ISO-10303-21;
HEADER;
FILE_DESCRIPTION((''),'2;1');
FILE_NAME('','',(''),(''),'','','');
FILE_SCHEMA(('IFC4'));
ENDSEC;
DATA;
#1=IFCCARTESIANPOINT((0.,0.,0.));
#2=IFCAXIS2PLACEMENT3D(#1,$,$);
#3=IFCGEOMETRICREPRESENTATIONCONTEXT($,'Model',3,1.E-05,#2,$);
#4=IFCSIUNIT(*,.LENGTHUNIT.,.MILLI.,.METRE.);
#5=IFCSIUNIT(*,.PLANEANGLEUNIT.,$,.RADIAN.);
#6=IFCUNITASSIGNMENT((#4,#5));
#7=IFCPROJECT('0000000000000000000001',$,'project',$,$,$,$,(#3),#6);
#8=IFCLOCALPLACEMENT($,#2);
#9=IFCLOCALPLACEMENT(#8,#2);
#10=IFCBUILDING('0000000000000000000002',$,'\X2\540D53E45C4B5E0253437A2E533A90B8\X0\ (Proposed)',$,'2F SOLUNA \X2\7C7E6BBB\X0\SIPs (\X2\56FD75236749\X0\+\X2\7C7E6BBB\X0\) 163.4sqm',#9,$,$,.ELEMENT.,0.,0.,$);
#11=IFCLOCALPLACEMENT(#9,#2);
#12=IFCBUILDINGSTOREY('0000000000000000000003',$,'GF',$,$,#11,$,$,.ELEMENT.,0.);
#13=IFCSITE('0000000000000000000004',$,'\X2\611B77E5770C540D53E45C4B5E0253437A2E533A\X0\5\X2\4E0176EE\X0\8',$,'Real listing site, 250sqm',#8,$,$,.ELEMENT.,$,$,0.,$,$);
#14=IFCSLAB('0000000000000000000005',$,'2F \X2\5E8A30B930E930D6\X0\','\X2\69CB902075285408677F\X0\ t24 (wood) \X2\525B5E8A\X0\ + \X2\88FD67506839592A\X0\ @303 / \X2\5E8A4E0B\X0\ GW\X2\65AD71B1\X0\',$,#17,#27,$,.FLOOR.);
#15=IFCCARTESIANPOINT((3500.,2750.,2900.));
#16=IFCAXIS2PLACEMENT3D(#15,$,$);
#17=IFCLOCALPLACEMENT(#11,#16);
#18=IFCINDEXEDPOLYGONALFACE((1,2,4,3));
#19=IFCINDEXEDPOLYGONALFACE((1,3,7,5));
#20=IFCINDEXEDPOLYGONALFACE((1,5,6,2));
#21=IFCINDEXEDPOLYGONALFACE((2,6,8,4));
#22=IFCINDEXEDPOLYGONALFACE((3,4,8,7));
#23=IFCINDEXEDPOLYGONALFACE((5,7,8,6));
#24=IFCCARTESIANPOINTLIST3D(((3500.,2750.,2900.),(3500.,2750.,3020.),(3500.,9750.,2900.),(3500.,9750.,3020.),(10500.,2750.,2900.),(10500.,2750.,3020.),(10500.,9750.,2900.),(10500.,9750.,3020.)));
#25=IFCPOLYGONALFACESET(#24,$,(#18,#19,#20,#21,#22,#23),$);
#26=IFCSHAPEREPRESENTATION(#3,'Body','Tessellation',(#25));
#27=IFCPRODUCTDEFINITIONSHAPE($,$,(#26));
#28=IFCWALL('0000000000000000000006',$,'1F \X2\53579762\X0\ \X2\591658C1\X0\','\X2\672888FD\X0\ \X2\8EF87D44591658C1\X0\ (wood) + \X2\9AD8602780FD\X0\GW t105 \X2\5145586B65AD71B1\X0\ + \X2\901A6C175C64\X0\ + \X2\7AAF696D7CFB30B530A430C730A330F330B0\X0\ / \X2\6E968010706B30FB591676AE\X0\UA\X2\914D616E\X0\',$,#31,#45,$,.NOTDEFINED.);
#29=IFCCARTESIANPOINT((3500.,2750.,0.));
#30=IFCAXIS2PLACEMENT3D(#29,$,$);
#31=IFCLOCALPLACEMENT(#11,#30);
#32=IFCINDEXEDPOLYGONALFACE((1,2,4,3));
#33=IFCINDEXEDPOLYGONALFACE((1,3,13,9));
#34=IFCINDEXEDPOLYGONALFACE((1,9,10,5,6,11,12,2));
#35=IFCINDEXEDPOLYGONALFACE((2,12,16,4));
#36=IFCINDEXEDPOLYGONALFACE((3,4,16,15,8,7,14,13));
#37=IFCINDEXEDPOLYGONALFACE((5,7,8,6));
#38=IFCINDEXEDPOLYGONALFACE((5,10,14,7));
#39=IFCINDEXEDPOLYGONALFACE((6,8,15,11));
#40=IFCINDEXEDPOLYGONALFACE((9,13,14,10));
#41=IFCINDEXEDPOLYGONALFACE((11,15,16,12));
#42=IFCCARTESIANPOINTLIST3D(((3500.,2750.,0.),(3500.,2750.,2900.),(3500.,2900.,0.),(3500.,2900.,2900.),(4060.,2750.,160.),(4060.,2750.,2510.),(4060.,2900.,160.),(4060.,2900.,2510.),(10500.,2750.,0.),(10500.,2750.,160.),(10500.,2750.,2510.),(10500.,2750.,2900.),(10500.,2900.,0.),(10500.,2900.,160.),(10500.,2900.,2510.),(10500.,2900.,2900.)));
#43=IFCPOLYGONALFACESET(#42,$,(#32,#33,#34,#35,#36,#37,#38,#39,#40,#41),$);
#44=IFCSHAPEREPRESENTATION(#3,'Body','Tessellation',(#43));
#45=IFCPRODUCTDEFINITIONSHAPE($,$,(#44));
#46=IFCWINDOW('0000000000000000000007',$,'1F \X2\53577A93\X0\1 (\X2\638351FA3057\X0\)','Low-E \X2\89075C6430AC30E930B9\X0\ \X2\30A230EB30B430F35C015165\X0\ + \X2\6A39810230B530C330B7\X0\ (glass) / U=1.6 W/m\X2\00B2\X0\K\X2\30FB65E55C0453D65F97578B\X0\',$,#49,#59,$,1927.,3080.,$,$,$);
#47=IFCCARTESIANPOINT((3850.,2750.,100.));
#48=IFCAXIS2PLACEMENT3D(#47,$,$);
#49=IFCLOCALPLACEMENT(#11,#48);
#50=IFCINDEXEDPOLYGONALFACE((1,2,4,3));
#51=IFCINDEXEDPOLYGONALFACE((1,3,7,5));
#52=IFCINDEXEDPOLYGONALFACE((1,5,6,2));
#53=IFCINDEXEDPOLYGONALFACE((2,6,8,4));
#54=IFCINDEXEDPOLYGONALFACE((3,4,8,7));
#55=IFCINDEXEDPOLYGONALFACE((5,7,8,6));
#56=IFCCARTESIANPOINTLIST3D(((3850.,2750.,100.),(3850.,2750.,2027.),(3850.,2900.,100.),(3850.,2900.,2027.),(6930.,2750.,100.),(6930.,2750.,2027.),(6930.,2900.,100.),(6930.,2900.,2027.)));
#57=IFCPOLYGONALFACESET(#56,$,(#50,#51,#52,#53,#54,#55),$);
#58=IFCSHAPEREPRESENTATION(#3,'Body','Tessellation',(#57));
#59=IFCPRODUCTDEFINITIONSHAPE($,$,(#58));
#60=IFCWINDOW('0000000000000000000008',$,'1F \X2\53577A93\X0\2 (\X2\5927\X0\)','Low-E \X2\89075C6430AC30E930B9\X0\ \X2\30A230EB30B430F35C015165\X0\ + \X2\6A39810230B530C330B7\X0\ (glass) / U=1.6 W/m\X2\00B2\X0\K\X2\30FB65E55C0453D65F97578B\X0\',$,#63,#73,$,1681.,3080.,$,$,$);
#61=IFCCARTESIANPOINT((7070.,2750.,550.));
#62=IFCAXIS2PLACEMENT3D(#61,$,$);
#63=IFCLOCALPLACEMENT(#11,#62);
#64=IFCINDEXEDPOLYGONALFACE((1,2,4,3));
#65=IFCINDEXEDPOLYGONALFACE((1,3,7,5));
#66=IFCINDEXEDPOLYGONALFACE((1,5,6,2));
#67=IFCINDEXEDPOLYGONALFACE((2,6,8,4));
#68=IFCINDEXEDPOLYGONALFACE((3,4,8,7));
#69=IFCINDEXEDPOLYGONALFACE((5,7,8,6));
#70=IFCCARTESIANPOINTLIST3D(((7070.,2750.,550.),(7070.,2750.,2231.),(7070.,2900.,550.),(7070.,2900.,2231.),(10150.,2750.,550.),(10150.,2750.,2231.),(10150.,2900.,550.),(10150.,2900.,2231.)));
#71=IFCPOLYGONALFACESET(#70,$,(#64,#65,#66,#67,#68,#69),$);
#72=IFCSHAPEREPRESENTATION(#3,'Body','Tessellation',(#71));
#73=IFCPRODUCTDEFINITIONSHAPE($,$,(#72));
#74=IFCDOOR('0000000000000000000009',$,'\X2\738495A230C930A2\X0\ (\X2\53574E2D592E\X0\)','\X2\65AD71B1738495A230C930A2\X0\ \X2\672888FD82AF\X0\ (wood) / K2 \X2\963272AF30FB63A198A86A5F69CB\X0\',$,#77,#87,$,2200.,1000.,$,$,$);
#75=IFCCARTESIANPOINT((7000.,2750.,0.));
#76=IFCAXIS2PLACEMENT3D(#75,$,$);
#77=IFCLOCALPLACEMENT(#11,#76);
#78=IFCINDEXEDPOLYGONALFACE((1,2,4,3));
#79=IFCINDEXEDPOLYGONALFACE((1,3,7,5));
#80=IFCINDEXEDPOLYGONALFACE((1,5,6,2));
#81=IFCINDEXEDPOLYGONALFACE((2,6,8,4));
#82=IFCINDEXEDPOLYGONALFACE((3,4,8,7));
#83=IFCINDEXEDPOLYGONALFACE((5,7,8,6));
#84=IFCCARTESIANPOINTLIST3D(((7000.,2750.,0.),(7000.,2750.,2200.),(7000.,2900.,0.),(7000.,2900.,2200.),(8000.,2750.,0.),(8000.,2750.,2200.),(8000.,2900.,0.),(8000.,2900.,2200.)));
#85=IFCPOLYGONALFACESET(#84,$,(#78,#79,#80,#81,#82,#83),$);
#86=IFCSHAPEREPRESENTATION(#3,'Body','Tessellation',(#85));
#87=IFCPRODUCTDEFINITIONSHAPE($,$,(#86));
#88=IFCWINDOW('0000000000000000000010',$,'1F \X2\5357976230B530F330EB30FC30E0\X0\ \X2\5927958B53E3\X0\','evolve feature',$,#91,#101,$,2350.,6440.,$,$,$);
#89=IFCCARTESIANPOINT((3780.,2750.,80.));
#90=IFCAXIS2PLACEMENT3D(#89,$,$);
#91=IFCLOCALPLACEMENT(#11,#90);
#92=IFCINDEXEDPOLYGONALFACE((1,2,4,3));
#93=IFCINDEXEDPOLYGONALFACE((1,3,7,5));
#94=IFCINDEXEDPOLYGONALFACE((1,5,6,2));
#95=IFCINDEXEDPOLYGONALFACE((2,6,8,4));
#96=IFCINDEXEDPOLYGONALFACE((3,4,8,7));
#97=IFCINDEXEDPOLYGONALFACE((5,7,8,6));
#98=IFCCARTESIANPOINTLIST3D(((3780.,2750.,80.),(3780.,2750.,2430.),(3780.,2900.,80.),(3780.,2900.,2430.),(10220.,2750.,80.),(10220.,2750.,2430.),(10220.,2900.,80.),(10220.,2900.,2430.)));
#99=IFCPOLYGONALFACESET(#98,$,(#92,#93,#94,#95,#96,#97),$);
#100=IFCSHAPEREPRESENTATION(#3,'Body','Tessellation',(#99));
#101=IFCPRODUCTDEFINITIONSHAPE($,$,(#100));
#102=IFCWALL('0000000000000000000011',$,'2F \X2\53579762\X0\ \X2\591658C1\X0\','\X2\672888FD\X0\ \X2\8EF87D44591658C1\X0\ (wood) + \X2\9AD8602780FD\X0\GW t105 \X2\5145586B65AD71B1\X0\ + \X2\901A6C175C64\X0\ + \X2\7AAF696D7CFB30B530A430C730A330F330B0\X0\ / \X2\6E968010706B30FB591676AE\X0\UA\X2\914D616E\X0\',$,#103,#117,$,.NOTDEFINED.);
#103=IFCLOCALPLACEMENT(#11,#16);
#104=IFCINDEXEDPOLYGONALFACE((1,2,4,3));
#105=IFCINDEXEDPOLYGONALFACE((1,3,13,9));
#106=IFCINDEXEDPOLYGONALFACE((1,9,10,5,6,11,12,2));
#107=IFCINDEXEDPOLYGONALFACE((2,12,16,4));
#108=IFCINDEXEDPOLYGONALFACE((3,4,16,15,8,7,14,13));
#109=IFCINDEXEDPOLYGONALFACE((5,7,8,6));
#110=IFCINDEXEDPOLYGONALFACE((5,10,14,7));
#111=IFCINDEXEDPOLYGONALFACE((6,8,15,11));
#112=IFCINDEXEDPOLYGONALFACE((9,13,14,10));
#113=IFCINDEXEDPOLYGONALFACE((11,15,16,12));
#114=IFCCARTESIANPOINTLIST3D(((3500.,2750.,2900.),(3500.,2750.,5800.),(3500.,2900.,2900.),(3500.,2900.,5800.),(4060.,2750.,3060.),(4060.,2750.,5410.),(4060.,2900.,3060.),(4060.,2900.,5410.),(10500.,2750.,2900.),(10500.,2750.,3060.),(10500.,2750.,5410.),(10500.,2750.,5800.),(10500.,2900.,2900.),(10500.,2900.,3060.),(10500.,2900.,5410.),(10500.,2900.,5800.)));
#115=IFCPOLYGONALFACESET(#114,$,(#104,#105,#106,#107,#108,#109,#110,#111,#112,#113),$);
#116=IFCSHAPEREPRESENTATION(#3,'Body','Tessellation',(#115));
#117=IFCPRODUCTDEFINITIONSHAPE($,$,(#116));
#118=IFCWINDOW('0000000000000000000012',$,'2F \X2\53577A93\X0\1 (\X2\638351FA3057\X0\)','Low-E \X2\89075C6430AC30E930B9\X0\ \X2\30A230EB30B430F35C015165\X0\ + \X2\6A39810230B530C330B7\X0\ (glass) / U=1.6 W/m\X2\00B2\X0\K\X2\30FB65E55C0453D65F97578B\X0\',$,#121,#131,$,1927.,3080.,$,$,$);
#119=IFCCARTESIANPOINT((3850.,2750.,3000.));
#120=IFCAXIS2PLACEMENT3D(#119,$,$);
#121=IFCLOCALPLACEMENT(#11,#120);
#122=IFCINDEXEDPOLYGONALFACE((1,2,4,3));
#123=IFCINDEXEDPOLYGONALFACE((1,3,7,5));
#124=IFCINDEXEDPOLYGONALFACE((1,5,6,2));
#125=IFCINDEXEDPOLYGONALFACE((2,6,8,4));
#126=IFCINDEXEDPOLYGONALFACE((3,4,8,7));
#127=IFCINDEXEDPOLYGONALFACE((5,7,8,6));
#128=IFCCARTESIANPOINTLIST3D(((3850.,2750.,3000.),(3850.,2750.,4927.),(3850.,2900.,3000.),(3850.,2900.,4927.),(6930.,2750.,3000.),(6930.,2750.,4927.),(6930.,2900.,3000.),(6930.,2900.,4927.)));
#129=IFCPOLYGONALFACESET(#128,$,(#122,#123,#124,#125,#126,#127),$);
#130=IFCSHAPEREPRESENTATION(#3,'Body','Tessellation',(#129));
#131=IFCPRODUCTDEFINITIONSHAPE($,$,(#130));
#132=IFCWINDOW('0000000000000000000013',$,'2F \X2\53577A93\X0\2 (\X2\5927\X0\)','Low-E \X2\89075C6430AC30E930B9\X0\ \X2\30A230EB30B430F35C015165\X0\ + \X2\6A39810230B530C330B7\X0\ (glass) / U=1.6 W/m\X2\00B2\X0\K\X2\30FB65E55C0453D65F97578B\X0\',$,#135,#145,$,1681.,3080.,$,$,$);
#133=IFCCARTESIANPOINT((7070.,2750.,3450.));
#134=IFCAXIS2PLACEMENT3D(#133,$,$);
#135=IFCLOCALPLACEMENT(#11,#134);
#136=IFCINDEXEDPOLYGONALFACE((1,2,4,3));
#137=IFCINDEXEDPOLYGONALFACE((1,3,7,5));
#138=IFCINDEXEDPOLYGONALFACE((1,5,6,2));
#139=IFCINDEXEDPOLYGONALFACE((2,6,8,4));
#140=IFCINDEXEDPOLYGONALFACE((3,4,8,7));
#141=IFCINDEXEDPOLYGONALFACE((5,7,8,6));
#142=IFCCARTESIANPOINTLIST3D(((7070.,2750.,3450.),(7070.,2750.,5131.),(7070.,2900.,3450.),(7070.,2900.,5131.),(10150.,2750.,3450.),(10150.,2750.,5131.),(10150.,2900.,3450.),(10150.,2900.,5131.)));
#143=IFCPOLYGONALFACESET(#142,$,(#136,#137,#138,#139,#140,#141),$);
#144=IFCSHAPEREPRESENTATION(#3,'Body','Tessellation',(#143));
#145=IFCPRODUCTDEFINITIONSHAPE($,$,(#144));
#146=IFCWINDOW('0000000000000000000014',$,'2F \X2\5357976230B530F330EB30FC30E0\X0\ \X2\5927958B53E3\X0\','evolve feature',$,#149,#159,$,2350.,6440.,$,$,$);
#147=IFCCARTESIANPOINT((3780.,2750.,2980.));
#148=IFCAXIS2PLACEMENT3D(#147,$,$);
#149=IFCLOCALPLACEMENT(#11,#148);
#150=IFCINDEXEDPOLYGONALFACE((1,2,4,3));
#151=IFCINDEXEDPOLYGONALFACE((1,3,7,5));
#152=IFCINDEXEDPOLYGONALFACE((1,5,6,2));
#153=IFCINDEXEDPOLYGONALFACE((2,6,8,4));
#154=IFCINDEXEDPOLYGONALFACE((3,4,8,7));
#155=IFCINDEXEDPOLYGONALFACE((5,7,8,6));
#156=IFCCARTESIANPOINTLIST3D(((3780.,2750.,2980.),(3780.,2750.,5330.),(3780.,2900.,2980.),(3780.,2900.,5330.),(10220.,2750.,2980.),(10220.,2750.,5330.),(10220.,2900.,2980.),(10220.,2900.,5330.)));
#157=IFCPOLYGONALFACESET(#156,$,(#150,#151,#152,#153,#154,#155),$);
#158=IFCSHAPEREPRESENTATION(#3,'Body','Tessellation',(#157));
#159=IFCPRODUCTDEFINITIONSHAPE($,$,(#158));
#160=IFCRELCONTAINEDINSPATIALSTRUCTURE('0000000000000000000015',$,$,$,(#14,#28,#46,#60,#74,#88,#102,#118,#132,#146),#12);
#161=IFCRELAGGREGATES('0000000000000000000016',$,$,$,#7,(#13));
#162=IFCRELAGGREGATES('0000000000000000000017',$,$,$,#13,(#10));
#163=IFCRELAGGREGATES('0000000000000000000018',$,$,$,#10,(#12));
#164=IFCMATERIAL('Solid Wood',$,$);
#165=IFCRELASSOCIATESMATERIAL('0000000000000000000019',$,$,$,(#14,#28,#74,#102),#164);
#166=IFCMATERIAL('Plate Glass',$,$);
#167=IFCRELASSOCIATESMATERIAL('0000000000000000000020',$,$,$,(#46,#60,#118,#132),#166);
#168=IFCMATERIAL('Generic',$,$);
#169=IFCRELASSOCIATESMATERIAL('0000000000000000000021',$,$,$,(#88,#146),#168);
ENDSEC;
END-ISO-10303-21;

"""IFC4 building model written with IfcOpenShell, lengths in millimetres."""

from ifc_helpers import new_model, si_unit, frame, frame_2d, origin, place, context, project, spatial, rectangle, extrude, material, element, fill, save


model = new_model("IFC4")

# Units and contexts
model_context = context("Model", 3, precision=1e-05, world=origin())
ifc_project = project(units=[si_unit("LENGTHUNIT", "METRE", prefix="MILLI"), si_unit("PLANEANGLEUNIT", "RADIAN")], contexts=[model_context])

# Site, building, storey
site_placement = place(None, origin())
site = spatial("IfcSite", under=ifc_project, at=site_placement, Name="愛知県名古屋市千種区5丁目8", ObjectType="Real listing site, 250sqm", CompositionType="ELEMENT", RefElevation=0.0)
building_placement = place(site_placement, origin())
building = spatial("IfcBuilding", under=site, at=building_placement, Name="名古屋市千種区邸 (Proposed)", ObjectType="2F SOLUNA 籾殻SIPs (国産杉+籾殻) 163.4sqm", CompositionType="ELEMENT", ElevationOfRefHeight=0.0, ElevationOfTerrain=0.0)
storey_placement = place(building_placement, origin())
storey = spatial("IfcBuildingStorey", under=building, at=storey_placement, Name="GF", CompositionType="ELEMENT", Elevation=0.0)

# Slab
ifc_material_1 = material(Name="Solid Wood")
slab_1_placement = place(storey_placement, frame((3500.0, 2750.0, 2900.0)))
element("IfcSlab", 1, at=slab_1_placement, inside=storey, material=ifc_material_1, Name="2F 床スラブ", Description="構造用合板 t24 (wood) 剛床 + 製材根太 @303 / 床下 GW断熱", PredefinedType="FLOOR", context=model_context, shape_type="SweptSolid", body=[
    extrude(rectangle(XDim=7000.0, YDim=7000.0, at=frame_2d((3500.0, 3500.0))), frame((3500.0, 2750.0, 2900.0)), (0.0, 0.0, 1.0), 120.0),
])
ifc_material_2 = material(Name="Generic")

# Wall, openings, windows, door
wall_1_placement = place(storey_placement, frame((3500.0, 2750.0, 0.0)))
wall_1 = element("IfcWall", 2, at=wall_1_placement, inside=storey, material=ifc_material_1, Name="1F 南面 外壁", Description="木製 軸組外壁 (wood) + 高性能GW t105 充填断熱 + 通気層 + 窯業系サイディング / 準耐火・外皮UA配慮", PredefinedType="NOTDEFINED", context=model_context, shape_type="SweptSolid", body=[
    extrude(rectangle(XDim=7000.0, YDim=150.0, at=frame_2d((3500.0, 75.0))), frame((3500.0, 2750.0, 0.0)), (0.0, 0.0, 1.0), 2900.0),
])
opening_1_placement = place(storey_placement, frame((3850.0, 2750.0, 100.0)))
opening_1 = element("IfcOpeningElement", 3, at=opening_1_placement, cuts=wall_1, PredefinedType="NOTDEFINED", context=model_context, shape_type="SweptSolid", body=[
    extrude(rectangle(XDim=3080.0, YDim=150.0, at=frame_2d((1540.0, 75.0))), frame((3850.0, 2750.0, 100.0)), (0.0, 0.0, 1.0), 1927.0),
])
opening_2_placement = place(storey_placement, frame((7070.0, 2750.0, 550.0)))
opening_2 = element("IfcOpeningElement", 4, at=opening_2_placement, cuts=wall_1, PredefinedType="NOTDEFINED", context=model_context, shape_type="SweptSolid", body=[
    extrude(rectangle(XDim=3080.0, YDim=150.0, at=frame_2d((1540.0, 75.0))), frame((7070.0, 2750.0, 550.0)), (0.0, 0.0, 1.0), 1681.0),
])
opening_3_placement = place(storey_placement, frame((7000.0, 2750.0, 0.0)))
opening_3 = element("IfcOpeningElement", 5, at=opening_3_placement, cuts=wall_1, PredefinedType="NOTDEFINED", context=model_context, shape_type="SweptSolid", body=[
    extrude(rectangle(XDim=1000.0, YDim=150.0, at=frame_2d((500.0, 75.0))), frame((7000.0, 2750.0, 0.0)), (0.0, 0.0, 1.0), 2200.0),
])
opening_4_placement = place(storey_placement, frame((3780.0, 2750.0, 80.0)))
opening_4 = element("IfcOpeningElement", 6, at=opening_4_placement, cuts=wall_1, PredefinedType="NOTDEFINED", context=model_context, shape_type="SweptSolid", body=[
    extrude(rectangle(XDim=6440.0, YDim=150.0, at=frame_2d((3220.0, 75.0))), frame((3780.0, 2750.0, 80.0)), (0.0, 0.0, 1.0), 2350.0),
])
ifc_material_3 = material(Name="Plate Glass")
window_1_placement = place(storey_placement, frame((3850.0, 2750.0, 100.0)))
window_1 = element("IfcWindow", 7, at=window_1_placement, inside=storey, material=ifc_material_3, Name="1F 南窓1 (掃出し)", Description="Low-E 複層ガラス アルゴン封入 + 樹脂サッシ (glass) / U=1.6 W/m²K・日射取得型", OverallHeight=1927.0, OverallWidth=3080.0, context=model_context, shape_type="SweptSolid", body=[
    extrude(rectangle(XDim=3080.0, YDim=150.0, at=frame_2d((1540.0, 75.0))), frame((3850.0, 2750.0, 100.0)), (0.0, 0.0, 1.0), 1927.0),
])
fill(opening_1, window_1)
window_2_placement = place(storey_placement, frame((7070.0, 2750.0, 550.0)))
window_2 = element("IfcWindow", 8, at=window_2_placement, inside=storey, material=ifc_material_3, Name="1F 南窓2 (大)", Description="Low-E 複層ガラス アルゴン封入 + 樹脂サッシ (glass) / U=1.6 W/m²K・日射取得型", OverallHeight=1681.0, OverallWidth=3080.0, context=model_context, shape_type="SweptSolid", body=[
    extrude(rectangle(XDim=3080.0, YDim=150.0, at=frame_2d((1540.0, 75.0))), frame((7070.0, 2750.0, 550.0)), (0.0, 0.0, 1.0), 1681.0),
])
fill(opening_2, window_2)
door_placement = place(storey_placement, frame((7000.0, 2750.0, 0.0)))
door = element("IfcDoor", 9, at=door_placement, inside=storey, material=ifc_material_1, Name="玄関ドア (南中央)", Description="断熱玄関ドア 木製芯 (wood) / K2 防犯・採風機構", OverallHeight=2200.0, OverallWidth=1000.0, context=model_context, shape_type="SweptSolid", body=[
    extrude(rectangle(XDim=1000.0, YDim=150.0, at=frame_2d((500.0, 75.0))), frame((7000.0, 2750.0, 0.0)), (0.0, 0.0, 1.0), 2200.0),
])
fill(opening_3, door)
window_3_placement = place(storey_placement, frame((3780.0, 2750.0, 80.0)))
window_3 = element("IfcWindow", 10, at=window_3_placement, inside=storey, material=ifc_material_2, Name="1F 南面サンルーム 大開口", Description="evolve feature", OverallHeight=2350.0, OverallWidth=6440.0, context=model_context, shape_type="SweptSolid", body=[
    extrude(rectangle(XDim=6440.0, YDim=150.0, at=frame_2d((3220.0, 75.0))), frame((3780.0, 2750.0, 80.0)), (0.0, 0.0, 1.0), 2350.0),
])
fill(opening_4, window_3)

# Wall, openings, windows
wall_2_placement = place(storey_placement, frame((3500.0, 2750.0, 2900.0)))
wall_2 = element("IfcWall", 11, at=wall_2_placement, inside=storey, material=ifc_material_1, Name="2F 南面 外壁", Description="木製 軸組外壁 (wood) + 高性能GW t105 充填断熱 + 通気層 + 窯業系サイディング / 準耐火・外皮UA配慮", PredefinedType="NOTDEFINED", context=model_context, shape_type="SweptSolid", body=[
    extrude(rectangle(XDim=7000.0, YDim=150.0, at=frame_2d((3500.0, 75.0))), frame((3500.0, 2750.0, 2900.0)), (0.0, 0.0, 1.0), 2900.0),
])
opening_5_placement = place(storey_placement, frame((3850.0, 2750.0, 3000.0)))
opening_5 = element("IfcOpeningElement", 12, at=opening_5_placement, cuts=wall_2, PredefinedType="NOTDEFINED", context=model_context, shape_type="SweptSolid", body=[
    extrude(rectangle(XDim=3080.0, YDim=150.0, at=frame_2d((1540.0, 75.0))), frame((3850.0, 2750.0, 3000.0)), (0.0, 0.0, 1.0), 1927.0),
])
opening_6_placement = place(storey_placement, frame((7070.0, 2750.0, 3450.0)))
opening_6 = element("IfcOpeningElement", 13, at=opening_6_placement, cuts=wall_2, PredefinedType="NOTDEFINED", context=model_context, shape_type="SweptSolid", body=[
    extrude(rectangle(XDim=3080.0, YDim=150.0, at=frame_2d((1540.0, 75.0))), frame((7070.0, 2750.0, 3450.0)), (0.0, 0.0, 1.0), 1681.0),
])
opening_7_placement = place(storey_placement, frame((3780.0, 2750.0, 2980.0)))
opening_7 = element("IfcOpeningElement", 14, at=opening_7_placement, cuts=wall_2, PredefinedType="NOTDEFINED", context=model_context, shape_type="SweptSolid", body=[
    extrude(rectangle(XDim=6440.0, YDim=150.0, at=frame_2d((3220.0, 75.0))), frame((3780.0, 2750.0, 2980.0)), (0.0, 0.0, 1.0), 2350.0),
])
window_4_placement = place(storey_placement, frame((3850.0, 2750.0, 3000.0)))
window_4 = element("IfcWindow", 15, at=window_4_placement, inside=storey, material=ifc_material_3, Name="2F 南窓1 (掃出し)", Description="Low-E 複層ガラス アルゴン封入 + 樹脂サッシ (glass) / U=1.6 W/m²K・日射取得型", OverallHeight=1927.0, OverallWidth=3080.0, context=model_context, shape_type="SweptSolid", body=[
    extrude(rectangle(XDim=3080.0, YDim=150.0, at=frame_2d((1540.0, 75.0))), frame((3850.0, 2750.0, 3000.0)), (0.0, 0.0, 1.0), 1927.0),
])
fill(opening_5, window_4)
window_5_placement = place(storey_placement, frame((7070.0, 2750.0, 3450.0)))
window_5 = element("IfcWindow", 16, at=window_5_placement, inside=storey, material=ifc_material_3, Name="2F 南窓2 (大)", Description="Low-E 複層ガラス アルゴン封入 + 樹脂サッシ (glass) / U=1.6 W/m²K・日射取得型", OverallHeight=1681.0, OverallWidth=3080.0, context=model_context, shape_type="SweptSolid", body=[
    extrude(rectangle(XDim=3080.0, YDim=150.0, at=frame_2d((1540.0, 75.0))), frame((7070.0, 2750.0, 3450.0)), (0.0, 0.0, 1.0), 1681.0),
])
fill(opening_6, window_5)
window_6_placement = place(storey_placement, frame((3780.0, 2750.0, 2980.0)))
window_6 = element("IfcWindow", 17, at=window_6_placement, inside=storey, material=ifc_material_2, Name="2F 南面サンルーム 大開口", Description="evolve feature", OverallHeight=2350.0, OverallWidth=6440.0, context=model_context, shape_type="SweptSolid", body=[
    extrude(rectangle(XDim=6440.0, YDim=150.0, at=frame_2d((3220.0, 75.0))), frame((3780.0, 2750.0, 2980.0)), (0.0, 0.0, 1.0), 2350.0),
])
fill(opening_7, window_6)

save(model, "model.ifc")
